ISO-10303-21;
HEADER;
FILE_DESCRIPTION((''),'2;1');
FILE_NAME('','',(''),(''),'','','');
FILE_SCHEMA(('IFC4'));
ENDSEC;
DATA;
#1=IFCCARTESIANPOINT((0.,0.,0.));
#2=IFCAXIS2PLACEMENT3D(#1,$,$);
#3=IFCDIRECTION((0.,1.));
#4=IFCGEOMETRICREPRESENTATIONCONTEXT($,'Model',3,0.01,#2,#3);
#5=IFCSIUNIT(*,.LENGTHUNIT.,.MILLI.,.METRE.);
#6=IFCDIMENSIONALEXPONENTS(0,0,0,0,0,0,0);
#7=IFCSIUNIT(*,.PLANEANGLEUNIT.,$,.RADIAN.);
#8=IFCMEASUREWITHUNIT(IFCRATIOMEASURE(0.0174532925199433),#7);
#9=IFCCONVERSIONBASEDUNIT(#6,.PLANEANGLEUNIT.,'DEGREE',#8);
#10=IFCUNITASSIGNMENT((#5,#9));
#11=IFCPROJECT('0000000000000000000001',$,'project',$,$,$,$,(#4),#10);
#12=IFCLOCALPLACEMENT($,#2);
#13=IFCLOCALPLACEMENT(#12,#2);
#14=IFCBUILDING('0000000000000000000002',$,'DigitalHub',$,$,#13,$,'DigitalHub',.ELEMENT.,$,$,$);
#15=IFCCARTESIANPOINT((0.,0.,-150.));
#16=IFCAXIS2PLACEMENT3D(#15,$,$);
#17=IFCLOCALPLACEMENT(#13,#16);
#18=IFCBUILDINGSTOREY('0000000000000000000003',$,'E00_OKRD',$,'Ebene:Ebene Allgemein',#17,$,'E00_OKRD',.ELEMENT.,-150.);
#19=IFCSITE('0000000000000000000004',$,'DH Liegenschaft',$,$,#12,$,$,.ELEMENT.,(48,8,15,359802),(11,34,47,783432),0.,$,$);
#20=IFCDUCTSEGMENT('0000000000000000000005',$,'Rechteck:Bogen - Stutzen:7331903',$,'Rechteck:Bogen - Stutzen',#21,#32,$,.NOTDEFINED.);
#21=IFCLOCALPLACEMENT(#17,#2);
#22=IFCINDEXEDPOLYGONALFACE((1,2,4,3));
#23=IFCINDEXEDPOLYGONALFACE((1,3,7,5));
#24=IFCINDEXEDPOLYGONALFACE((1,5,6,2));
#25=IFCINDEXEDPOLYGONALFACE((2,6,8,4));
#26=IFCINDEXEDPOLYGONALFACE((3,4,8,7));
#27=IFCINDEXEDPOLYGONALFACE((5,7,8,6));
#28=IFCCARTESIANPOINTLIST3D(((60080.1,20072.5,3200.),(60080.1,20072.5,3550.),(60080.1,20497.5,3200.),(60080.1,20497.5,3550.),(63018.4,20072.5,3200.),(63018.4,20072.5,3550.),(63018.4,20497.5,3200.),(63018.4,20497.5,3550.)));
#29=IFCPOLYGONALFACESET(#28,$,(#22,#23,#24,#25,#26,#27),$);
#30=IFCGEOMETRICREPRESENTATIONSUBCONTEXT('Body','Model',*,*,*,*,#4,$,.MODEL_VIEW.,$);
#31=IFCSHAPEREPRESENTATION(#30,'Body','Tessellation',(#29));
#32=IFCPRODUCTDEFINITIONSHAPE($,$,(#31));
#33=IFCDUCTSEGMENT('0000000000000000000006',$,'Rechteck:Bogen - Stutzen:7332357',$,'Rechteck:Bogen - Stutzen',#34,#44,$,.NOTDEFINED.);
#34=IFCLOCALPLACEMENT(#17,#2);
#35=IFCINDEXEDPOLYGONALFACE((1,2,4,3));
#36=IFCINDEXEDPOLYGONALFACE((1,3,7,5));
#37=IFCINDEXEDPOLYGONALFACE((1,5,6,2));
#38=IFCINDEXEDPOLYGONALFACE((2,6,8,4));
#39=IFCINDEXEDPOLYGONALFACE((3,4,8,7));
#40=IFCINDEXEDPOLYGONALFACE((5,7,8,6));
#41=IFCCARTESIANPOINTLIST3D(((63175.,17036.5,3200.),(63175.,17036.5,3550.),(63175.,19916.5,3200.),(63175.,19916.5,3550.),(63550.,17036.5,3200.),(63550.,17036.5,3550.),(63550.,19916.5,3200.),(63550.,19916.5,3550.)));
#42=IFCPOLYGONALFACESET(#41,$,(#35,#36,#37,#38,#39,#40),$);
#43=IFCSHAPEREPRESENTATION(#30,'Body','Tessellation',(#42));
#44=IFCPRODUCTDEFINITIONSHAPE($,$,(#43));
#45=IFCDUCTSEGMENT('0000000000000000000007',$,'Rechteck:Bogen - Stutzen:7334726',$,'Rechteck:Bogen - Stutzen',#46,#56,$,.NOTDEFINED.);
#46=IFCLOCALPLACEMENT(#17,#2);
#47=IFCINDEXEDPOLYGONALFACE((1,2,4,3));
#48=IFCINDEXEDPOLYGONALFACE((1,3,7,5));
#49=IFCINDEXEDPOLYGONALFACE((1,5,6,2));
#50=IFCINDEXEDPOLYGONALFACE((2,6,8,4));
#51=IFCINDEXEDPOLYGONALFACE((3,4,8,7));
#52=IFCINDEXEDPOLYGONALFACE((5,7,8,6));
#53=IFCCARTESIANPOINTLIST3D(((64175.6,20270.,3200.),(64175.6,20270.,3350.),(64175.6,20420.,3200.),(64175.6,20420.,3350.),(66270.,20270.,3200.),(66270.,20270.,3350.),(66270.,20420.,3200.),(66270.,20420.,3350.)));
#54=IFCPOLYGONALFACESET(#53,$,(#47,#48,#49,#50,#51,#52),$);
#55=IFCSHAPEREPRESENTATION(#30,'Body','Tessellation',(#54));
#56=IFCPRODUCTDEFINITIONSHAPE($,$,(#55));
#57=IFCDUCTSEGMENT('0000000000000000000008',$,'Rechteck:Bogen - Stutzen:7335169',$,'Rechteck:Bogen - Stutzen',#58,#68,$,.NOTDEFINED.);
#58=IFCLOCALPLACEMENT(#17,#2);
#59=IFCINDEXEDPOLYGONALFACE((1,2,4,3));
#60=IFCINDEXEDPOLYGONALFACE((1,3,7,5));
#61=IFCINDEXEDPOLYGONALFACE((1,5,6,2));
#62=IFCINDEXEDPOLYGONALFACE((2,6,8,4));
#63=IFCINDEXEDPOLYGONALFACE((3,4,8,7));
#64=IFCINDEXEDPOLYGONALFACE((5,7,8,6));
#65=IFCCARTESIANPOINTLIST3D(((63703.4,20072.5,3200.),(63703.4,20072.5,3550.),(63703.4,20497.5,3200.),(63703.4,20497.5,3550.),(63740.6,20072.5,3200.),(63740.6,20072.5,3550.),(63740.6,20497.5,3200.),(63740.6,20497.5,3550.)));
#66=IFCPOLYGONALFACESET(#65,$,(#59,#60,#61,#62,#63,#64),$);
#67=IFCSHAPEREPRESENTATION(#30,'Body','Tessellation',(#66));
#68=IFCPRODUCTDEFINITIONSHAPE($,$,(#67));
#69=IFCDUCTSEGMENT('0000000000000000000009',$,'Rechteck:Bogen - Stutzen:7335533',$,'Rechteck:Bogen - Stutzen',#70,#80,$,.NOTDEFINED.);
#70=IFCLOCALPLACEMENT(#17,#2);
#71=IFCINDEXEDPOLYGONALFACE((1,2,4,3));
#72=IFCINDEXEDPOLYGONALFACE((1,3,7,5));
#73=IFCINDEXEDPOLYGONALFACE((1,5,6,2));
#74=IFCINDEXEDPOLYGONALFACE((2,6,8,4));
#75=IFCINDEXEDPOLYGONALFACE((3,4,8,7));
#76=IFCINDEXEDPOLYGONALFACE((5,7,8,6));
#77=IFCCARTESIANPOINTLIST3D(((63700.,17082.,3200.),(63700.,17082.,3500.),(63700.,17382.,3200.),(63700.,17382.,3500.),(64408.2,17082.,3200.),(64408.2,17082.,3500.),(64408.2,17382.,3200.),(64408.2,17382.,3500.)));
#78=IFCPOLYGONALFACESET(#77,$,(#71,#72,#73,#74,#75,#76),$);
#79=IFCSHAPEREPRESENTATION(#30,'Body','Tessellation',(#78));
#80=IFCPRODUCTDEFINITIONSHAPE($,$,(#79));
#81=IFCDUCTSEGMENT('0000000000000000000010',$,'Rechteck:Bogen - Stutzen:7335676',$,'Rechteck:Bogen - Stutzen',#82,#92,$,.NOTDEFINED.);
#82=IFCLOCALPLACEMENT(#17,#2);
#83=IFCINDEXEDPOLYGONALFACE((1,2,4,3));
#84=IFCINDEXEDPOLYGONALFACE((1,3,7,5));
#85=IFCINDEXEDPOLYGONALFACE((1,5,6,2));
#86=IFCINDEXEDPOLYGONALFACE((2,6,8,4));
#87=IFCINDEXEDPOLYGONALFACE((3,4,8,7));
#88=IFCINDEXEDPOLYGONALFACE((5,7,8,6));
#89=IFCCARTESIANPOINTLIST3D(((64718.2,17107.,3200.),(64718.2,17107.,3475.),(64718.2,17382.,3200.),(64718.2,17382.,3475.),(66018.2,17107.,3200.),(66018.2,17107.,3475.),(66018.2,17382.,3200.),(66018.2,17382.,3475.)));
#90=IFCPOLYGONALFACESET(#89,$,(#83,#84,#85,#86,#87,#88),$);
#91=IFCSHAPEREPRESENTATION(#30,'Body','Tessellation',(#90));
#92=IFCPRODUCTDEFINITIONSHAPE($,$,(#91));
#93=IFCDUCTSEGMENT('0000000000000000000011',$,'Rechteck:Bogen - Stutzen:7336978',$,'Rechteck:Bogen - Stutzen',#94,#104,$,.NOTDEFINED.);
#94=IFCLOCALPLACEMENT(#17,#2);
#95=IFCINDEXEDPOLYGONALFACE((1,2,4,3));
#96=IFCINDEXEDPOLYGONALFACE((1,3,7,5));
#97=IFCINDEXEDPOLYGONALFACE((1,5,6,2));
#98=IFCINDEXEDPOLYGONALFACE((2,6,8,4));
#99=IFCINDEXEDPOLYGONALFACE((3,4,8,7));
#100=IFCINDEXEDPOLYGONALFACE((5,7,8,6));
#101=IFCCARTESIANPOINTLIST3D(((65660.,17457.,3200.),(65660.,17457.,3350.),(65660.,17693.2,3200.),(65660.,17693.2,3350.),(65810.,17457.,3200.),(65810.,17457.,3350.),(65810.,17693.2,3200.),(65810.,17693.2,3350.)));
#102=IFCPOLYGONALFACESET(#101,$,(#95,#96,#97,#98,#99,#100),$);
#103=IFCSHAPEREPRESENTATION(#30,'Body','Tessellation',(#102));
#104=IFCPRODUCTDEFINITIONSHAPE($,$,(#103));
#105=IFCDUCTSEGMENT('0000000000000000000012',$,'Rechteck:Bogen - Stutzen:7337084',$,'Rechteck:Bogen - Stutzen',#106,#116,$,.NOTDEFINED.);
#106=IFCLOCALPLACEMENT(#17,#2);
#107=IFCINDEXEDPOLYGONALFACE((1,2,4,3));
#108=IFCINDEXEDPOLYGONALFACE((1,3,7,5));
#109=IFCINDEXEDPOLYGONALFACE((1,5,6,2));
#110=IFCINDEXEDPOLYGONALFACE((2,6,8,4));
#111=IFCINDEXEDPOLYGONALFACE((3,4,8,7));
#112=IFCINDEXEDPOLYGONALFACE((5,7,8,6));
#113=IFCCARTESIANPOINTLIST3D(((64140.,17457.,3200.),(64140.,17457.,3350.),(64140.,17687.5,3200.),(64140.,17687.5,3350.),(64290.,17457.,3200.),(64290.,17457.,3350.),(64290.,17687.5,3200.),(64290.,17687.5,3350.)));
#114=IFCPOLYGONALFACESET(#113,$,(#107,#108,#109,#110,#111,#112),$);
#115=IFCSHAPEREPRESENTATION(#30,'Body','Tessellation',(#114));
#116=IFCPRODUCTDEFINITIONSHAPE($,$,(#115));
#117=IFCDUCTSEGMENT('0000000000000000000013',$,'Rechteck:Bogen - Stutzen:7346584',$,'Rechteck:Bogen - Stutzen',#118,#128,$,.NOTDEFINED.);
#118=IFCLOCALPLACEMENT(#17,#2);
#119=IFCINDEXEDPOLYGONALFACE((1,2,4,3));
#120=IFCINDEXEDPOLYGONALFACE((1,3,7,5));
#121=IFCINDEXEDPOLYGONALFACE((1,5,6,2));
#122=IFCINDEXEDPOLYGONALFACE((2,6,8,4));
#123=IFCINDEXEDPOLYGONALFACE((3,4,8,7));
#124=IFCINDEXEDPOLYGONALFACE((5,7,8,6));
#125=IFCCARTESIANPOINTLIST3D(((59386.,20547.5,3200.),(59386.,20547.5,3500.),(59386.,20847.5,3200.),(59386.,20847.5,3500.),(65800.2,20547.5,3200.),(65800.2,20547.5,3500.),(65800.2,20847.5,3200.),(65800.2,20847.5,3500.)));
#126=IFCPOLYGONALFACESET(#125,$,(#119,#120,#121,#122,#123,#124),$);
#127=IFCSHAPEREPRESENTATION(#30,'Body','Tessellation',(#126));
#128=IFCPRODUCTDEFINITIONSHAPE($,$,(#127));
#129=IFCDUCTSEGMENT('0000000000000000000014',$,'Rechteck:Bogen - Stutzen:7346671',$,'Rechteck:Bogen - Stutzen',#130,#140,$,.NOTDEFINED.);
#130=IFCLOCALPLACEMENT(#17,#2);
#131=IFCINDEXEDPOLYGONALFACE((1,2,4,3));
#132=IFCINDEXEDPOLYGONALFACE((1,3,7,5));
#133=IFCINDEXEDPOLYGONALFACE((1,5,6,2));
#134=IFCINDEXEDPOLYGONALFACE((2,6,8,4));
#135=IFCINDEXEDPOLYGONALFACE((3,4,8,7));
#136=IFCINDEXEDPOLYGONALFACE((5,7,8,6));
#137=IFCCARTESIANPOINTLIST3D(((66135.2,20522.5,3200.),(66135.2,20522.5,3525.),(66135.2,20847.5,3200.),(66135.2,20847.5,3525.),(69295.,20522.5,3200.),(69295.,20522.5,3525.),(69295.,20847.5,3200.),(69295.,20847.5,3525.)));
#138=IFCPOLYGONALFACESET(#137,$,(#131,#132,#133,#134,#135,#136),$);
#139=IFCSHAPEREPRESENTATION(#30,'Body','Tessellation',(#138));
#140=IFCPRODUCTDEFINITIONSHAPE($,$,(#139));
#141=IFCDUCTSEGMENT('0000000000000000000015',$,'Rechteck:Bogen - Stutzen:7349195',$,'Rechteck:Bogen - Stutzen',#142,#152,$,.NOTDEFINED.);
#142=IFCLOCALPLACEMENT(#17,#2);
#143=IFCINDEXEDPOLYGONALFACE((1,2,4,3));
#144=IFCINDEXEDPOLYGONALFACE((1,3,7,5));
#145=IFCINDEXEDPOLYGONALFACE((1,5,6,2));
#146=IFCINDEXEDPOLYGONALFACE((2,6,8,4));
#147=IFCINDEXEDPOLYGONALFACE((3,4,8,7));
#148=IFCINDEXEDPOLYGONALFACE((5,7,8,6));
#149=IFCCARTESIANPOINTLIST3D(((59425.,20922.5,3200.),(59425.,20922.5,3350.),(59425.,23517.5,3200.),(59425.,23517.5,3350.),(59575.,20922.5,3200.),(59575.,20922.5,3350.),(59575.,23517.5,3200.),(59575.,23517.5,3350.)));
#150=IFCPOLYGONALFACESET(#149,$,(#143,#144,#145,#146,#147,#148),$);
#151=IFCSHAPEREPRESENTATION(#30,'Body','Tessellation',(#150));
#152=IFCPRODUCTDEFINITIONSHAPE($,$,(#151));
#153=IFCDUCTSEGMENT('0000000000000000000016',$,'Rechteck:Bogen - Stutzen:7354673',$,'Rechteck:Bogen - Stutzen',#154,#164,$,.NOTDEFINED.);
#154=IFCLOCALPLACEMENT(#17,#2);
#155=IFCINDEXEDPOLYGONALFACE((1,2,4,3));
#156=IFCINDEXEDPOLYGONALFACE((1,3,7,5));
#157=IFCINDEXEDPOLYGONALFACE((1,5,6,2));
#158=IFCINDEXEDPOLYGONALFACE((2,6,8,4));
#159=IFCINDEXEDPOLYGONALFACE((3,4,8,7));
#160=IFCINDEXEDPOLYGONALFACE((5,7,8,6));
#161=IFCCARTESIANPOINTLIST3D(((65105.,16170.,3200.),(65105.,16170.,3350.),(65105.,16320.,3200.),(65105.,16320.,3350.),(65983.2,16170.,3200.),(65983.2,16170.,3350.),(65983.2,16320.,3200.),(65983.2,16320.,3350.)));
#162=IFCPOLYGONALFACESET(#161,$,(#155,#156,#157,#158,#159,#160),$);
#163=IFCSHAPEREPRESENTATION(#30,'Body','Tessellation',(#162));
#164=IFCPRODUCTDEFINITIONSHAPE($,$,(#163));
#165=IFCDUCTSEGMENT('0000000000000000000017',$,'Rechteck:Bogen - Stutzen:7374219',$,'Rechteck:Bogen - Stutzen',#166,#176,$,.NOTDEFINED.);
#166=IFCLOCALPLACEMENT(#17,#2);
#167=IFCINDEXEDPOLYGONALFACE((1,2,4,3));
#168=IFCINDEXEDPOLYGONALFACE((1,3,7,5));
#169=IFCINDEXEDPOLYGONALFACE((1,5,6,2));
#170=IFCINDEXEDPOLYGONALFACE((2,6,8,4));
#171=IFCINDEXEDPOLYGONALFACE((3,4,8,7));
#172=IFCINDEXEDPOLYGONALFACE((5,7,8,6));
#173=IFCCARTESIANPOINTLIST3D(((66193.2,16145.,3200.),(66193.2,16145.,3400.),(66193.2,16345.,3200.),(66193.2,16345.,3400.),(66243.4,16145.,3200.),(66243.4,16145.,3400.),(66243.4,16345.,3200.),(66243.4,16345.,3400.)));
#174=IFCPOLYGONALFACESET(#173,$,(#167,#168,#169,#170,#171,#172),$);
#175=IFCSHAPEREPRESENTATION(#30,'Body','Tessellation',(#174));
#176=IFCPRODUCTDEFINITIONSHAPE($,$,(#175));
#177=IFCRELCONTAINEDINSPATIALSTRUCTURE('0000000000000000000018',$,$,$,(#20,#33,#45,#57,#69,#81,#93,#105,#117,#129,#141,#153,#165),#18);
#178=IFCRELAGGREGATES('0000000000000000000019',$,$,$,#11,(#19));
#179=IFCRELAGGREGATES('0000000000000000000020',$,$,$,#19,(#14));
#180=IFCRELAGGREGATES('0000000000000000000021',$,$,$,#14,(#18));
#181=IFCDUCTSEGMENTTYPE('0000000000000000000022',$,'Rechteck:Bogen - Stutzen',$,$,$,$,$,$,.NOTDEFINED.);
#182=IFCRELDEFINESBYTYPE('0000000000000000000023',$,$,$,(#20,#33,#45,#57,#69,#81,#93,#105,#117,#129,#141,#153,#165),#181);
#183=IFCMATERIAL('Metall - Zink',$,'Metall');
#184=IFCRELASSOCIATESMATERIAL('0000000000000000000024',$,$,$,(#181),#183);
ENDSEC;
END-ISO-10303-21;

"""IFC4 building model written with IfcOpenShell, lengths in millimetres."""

from ifc_helpers import new_model, entity, si_unit, converted_unit, direction, frame, origin, place, context, subcontext, project, spatial, indexed_curve, outline, extrude, material, type_object, element, save


model = new_model("IFC4")

# Units and contexts
model_context = context("Model", 3, precision=0.01, world=origin(), true_north=direction((0.0, 1.0)))
body_context = subcontext(model_context, "Body", "Model", "MODEL_VIEW")
ifc_project = project(units=[si_unit("LENGTHUNIT", "METRE", prefix="MILLI"), converted_unit("PLANEANGLEUNIT", "DEGREE", entity("IfcRatioMeasure", 0.0174532925199433), si_unit("PLANEANGLEUNIT", "RADIAN"), dimensions=[0, 0, 0, 0, 0, 0, 0])], contexts=[model_context])

# Site, building, storey
site_placement = place(None, origin())
site = spatial("IfcSite", under=ifc_project, at=site_placement, Name="DH Liegenschaft", CompositionType="ELEMENT", RefLatitude=(48, 8, 15, 359802), RefLongitude=(11, 34, 47, 783432), RefElevation=0.0)
building_placement = place(site_placement, origin())
building = spatial("IfcBuilding", under=site, at=building_placement, Name="DigitalHub", LongName="DigitalHub", CompositionType="ELEMENT")
storey_placement = place(building_placement, frame((0.0, 0.0, -150.0)))
storey = spatial("IfcBuildingStorey", under=building, at=storey_placement, Name="E00_OKRD", ObjectType="Ebene:Ebene Allgemein", LongName="E00_OKRD", CompositionType="ELEMENT", Elevation=-150.0)

# Duct segments
ifc_material_1 = material(Name="Metall - Zink", Category="Metall")
duct_segment_type_1 = type_object("IfcDuctSegmentType", Name="Rechteck:Bogen - Stutzen", PredefinedType="NOTDEFINED", material=ifc_material_1)
duct_segment_1_placement = place(storey_placement, frame((60080.1, 20072.5, 3200.0)))
element("IfcDuctSegment", 1, at=duct_segment_1_placement, inside=storey, type_object=duct_segment_type_1, Name="Rechteck:Bogen - Stutzen:7331903", ObjectType="Rechteck:Bogen - Stutzen", PredefinedType="NOTDEFINED", context=body_context, shape_type="SweptSolid", body=[
    extrude(outline(indexed_curve([(-1469.1, -212.5), (1469.1, -212.5), (1469.1, 212.5), (-1469.1, 212.5), (-1469.1, -212.5)], self_intersect=False)), frame((1469.1, 212.5, 0.0)), (0.0, 0.0, 1.0), 350.0),
])
duct_segment_2_placement = place(storey_placement, frame((63175.0, 17036.5, 3200.0)))
element("IfcDuctSegment", 2, at=duct_segment_2_placement, inside=storey, type_object=duct_segment_type_1, Name="Rechteck:Bogen - Stutzen:7332357", ObjectType="Rechteck:Bogen - Stutzen", PredefinedType="NOTDEFINED", context=body_context, shape_type="SweptSolid", body=[
    extrude(outline(indexed_curve([(-1440.0, -187.5), (1440.0, -187.5), (1440.0, 187.5), (-1440.0, 187.5), (-1440.0, -187.5)], self_intersect=False)), frame((187.5, 1440.0, 0.0), z_axis=(0.0, 0.0, 1.0), x_axis=(0.0, -1.0, 0.0)), (0.0, 0.0, 1.0), 350.0),
])
duct_segment_3_placement = place(storey_placement, frame((64175.6, 20270.0, 3200.0)))
element("IfcDuctSegment", 3, at=duct_segment_3_placement, inside=storey, type_object=duct_segment_type_1, Name="Rechteck:Bogen - Stutzen:7334726", ObjectType="Rechteck:Bogen - Stutzen", PredefinedType="NOTDEFINED", context=body_context, shape_type="SweptSolid", body=[
    extrude(outline(indexed_curve([(-1047.2, -75.0), (1047.2, -75.0), (1047.2, 75.0), (-1047.2, 75.0), (-1047.2, -75.0)], self_intersect=False)), frame((1047.2, 75.0, 0.0), z_axis=(0.0, 0.0, 1.0), x_axis=(-1.0, 0.0, 0.0)), (0.0, 0.0, 1.0), 150.0),
])
duct_segment_4_placement = place(storey_placement, frame((63703.4, 20072.5, 3200.0)))
element("IfcDuctSegment", 4, at=duct_segment_4_placement, inside=storey, type_object=duct_segment_type_1, Name="Rechteck:Bogen - Stutzen:7335169", ObjectType="Rechteck:Bogen - Stutzen", PredefinedType="NOTDEFINED", context=body_context, shape_type="SweptSolid", body=[
    extrude(outline(indexed_curve([(-18.6, -212.5), (18.6, -212.5), (18.6, 212.5), (-18.6, 212.5), (-18.6, -212.5)], self_intersect=False)), frame((18.6, 212.5, 0.0)), (0.0, 0.0, 1.0), 350.0),
])
duct_segment_5_placement = place(storey_placement, frame((63700.0, 17082.0, 3200.0)))
element("IfcDuctSegment", 5, at=duct_segment_5_placement, inside=storey, type_object=duct_segment_type_1, Name="Rechteck:Bogen - Stutzen:7335533", ObjectType="Rechteck:Bogen - Stutzen", PredefinedType="NOTDEFINED", context=body_context, shape_type="SweptSolid", body=[
    extrude(outline(indexed_curve([(-354.1, -150.0), (354.1, -150.0), (354.1, 150.0), (-354.1, 150.0), (-354.1, -150.0)], self_intersect=False)), frame((354.1, 150.0, 0.0)), (0.0, 0.0, 1.0), 300.0),
])
duct_segment_6_placement = place(storey_placement, frame((64718.2, 17107.0, 3200.0)))
element("IfcDuctSegment", 6, at=duct_segment_6_placement, inside=storey, type_object=duct_segment_type_1, Name="Rechteck:Bogen - Stutzen:7335676", ObjectType="Rechteck:Bogen - Stutzen", PredefinedType="NOTDEFINED", context=body_context, shape_type="SweptSolid", body=[
    extrude(outline(indexed_curve([(-650.0, -137.5), (650.0, -137.5), (650.0, 137.5), (-650.0, 137.5), (-650.0, -137.5)], self_intersect=False)), frame((650.0, 137.5, 0.0)), (0.0, 0.0, 1.0), 275.0),
])
duct_segment_7_placement = place(storey_placement, frame((65660.0, 17457.0, 3200.0)))
element("IfcDuctSegment", 7, at=duct_segment_7_placement, inside=storey, type_object=duct_segment_type_1, Name="Rechteck:Bogen - Stutzen:7336978", ObjectType="Rechteck:Bogen - Stutzen", PredefinedType="NOTDEFINED", context=body_context, shape_type="SweptSolid", body=[
    extrude(outline(indexed_curve([(-118.1, -75.0), (118.1, -75.0), (118.1, 75.0), (-118.1, 75.0), (-118.1, -75.0)], self_intersect=False)), frame((75.0, 118.1, 0.0), z_axis=(0.0, 0.0, 1.0), x_axis=(0.0, 1.0, 0.0)), (0.0, 0.0, 1.0), 150.0),
])
duct_segment_8_placement = place(storey_placement, frame((64140.0, 17457.0, 3200.0)))
element("IfcDuctSegment", 8, at=duct_segment_8_placement, inside=storey, type_object=duct_segment_type_1, Name="Rechteck:Bogen - Stutzen:7337084", ObjectType="Rechteck:Bogen - Stutzen", PredefinedType="NOTDEFINED", context=body_context, shape_type="SweptSolid", body=[
    extrude(outline(indexed_curve([(-115.2, -75.0), (115.2, -75.0), (115.2, 75.0), (-115.2, 75.0), (-115.2, -75.0)], self_intersect=False)), frame((75.0, 115.2, 0.0), z_axis=(0.0, 0.0, 1.0), x_axis=(0.0, 1.0, 0.0)), (0.0, 0.0, 1.0), 150.0),
])
duct_segment_9_placement = place(storey_placement, frame((59386.0, 20547.5, 3200.0)))
element("IfcDuctSegment", 9, at=duct_segment_9_placement, inside=storey, type_object=duct_segment_type_1, Name="Rechteck:Bogen - Stutzen:7346584", ObjectType="Rechteck:Bogen - Stutzen", PredefinedType="NOTDEFINED", context=body_context, shape_type="SweptSolid", body=[
    extrude(outline(indexed_curve([(-3207.1, -150.0), (3207.1, -150.0), (3207.1, 150.0), (-3207.1, 150.0), (-3207.1, -150.0)], self_intersect=False)), frame((3207.1, 150.0, 0.0)), (0.0, 0.0, 1.0), 300.0),
])
duct_segment_10_placement = place(storey_placement, frame((66135.2, 20522.5, 3200.0)))
element("IfcDuctSegment", 10, at=duct_segment_10_placement, inside=storey, type_object=duct_segment_type_1, Name="Rechteck:Bogen - Stutzen:7346671", ObjectType="Rechteck:Bogen - Stutzen", PredefinedType="NOTDEFINED", context=body_context, shape_type="SweptSolid", body=[
    extrude(outline(indexed_curve([(-1579.9, -162.5), (1579.9, -162.5), (1579.9, 162.5), (-1579.9, 162.5), (-1579.9, -162.5)], self_intersect=False)), frame((1579.9, 162.5, 0.0)), (0.0, 0.0, 1.0), 325.0),
])
duct_segment_11_placement = place(storey_placement, frame((59425.0, 20922.5, 3200.0)))
element("IfcDuctSegment", 11, at=duct_segment_11_placement, inside=storey, type_object=duct_segment_type_1, Name="Rechteck:Bogen - Stutzen:7349195", ObjectType="Rechteck:Bogen - Stutzen", PredefinedType="NOTDEFINED", context=body_context, shape_type="SweptSolid", body=[
    extrude(outline(indexed_curve([(-1297.5, -75.0), (1297.5, -75.0), (1297.5, 75.0), (-1297.5, 75.0), (-1297.5, -75.0)], self_intersect=False)), frame((75.0, 1297.5, 0.0), z_axis=(0.0, 0.0, 1.0), x_axis=(0.0, 1.0, 0.0)), (0.0, 0.0, 1.0), 150.0),
])
duct_segment_12_placement = place(storey_placement, frame((65105.0, 16170.0, 3200.0)))
element("IfcDuctSegment", 12, at=duct_segment_12_placement, inside=storey, type_object=duct_segment_type_1, Name="Rechteck:Bogen - Stutzen:7354673", ObjectType="Rechteck:Bogen - Stutzen", PredefinedType="NOTDEFINED", context=body_context, shape_type="SweptSolid", body=[
    extrude(outline(indexed_curve([(-439.1, -75.0), (439.1, -75.0), (439.1, 75.0), (-439.1, 75.0), (-439.1, -75.0)], self_intersect=False)), frame((439.1, 75.0, 0.0)), (0.0, 0.0, 1.0), 150.0),
])
duct_segment_13_placement = place(storey_placement, frame((66193.2, 16145.0, 3200.0)))
element("IfcDuctSegment", 13, at=duct_segment_13_placement, inside=storey, type_object=duct_segment_type_1, Name="Rechteck:Bogen - Stutzen:7374219", ObjectType="Rechteck:Bogen - Stutzen", PredefinedType="NOTDEFINED", context=body_context, shape_type="SweptSolid", body=[
    extrude(outline(indexed_curve([(-25.1, -100.0), (25.1, -100.0), (25.1, 100.0), (-25.1, 100.0), (-25.1, -100.0)], self_intersect=False)), frame((25.1, 100.0, 0.0), z_axis=(0.0, 0.0, 1.0), x_axis=(-1.0, 0.0, 0.0)), (0.0, 0.0, 1.0), 200.0),
])

save(model, "model.ifc")
